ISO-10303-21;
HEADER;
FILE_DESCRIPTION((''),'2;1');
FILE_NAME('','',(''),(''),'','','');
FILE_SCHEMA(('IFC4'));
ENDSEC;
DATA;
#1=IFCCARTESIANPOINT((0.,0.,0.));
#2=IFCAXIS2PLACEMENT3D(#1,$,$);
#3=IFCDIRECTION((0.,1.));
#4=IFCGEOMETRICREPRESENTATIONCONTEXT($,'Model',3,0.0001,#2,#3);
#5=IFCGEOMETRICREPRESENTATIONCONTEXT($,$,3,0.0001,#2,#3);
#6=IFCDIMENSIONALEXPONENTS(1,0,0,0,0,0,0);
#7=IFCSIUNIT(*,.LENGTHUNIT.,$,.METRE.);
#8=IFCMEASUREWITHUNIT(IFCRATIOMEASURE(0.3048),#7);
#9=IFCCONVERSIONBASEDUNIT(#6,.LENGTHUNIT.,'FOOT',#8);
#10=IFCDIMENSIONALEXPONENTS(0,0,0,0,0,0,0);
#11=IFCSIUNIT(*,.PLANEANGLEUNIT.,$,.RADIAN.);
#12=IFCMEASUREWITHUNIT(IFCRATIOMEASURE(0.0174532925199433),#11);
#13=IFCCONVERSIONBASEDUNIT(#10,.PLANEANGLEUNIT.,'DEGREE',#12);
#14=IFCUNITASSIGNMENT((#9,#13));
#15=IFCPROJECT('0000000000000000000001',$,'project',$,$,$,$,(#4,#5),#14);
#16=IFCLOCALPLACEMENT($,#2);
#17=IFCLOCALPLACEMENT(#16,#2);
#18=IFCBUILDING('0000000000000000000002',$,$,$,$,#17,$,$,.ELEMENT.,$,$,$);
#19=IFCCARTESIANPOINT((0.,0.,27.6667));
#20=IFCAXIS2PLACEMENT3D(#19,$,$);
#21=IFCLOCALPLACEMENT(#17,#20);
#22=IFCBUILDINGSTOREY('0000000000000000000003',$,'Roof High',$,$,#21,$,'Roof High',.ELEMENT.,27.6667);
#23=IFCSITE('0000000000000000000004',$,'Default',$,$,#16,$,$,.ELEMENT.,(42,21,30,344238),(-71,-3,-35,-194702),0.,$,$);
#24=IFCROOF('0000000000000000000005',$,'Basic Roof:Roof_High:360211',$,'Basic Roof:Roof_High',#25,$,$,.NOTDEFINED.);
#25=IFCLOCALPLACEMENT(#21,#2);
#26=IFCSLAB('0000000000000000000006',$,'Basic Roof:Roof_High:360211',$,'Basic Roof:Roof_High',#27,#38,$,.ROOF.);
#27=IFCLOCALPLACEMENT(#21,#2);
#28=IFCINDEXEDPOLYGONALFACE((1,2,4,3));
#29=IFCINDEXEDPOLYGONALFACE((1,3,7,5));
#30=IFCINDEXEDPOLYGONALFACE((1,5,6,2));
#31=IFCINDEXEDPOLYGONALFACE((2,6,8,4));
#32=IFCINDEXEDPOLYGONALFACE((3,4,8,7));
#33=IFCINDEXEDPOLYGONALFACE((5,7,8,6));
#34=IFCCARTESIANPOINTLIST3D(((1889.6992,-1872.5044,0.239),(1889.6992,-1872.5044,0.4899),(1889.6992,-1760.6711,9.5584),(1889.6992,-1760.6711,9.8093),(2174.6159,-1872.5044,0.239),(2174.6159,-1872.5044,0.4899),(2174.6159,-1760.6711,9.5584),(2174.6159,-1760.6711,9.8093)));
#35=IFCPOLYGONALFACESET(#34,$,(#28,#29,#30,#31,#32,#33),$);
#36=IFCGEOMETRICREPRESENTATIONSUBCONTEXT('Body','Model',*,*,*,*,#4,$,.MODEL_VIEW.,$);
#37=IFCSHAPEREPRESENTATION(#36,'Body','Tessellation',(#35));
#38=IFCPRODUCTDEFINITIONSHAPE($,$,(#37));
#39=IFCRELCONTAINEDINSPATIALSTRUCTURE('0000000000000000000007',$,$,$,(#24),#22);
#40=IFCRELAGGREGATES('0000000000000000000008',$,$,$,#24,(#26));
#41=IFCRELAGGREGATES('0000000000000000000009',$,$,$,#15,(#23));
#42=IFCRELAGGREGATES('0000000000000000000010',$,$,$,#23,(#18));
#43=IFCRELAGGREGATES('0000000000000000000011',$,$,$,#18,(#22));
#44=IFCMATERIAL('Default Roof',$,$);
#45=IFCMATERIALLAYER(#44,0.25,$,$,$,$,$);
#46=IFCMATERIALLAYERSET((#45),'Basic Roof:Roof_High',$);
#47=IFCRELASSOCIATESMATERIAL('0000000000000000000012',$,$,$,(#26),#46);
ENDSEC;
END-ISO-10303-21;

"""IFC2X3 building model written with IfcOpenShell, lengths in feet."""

from ifc_helpers import new_model, entity, si_unit, converted_unit, direction, frame, frame_2d, origin, place, context, subcontext, project, spatial, rectangle, extrude, material, layer, layer_set, element, aggregate, save


model = new_model("IFC2X3")

# Units and contexts
model_context = context("Model", 3, precision=0.0001, world=origin(), true_north=direction((0.0, 1.0)))
context_of_model = context(None, 3, precision=0.0001, world=origin(), true_north=direction((0.0, 1.0)))
body_context = subcontext(model_context, "Body", "Model", "MODEL_VIEW")
ifc_project = project(units=[converted_unit("LENGTHUNIT", "FOOT", entity("IfcRatioMeasure", 0.3048), si_unit("LENGTHUNIT", "METRE"), dimensions=[1, 0, 0, 0, 0, 0, 0]), converted_unit("PLANEANGLEUNIT", "DEGREE", entity("IfcRatioMeasure", 0.0174532925199433), si_unit("PLANEANGLEUNIT", "RADIAN"), dimensions=[0, 0, 0, 0, 0, 0, 0])], contexts=[model_context, context_of_model])

# Site, building, storey
site_placement = place(None, origin())
site = spatial("IfcSite", under=ifc_project, at=site_placement, Name="Default", CompositionType="ELEMENT", RefLatitude=(42, 21, 30, 344238), RefLongitude=(-71, -3, -35, -194702), RefElevation=0.0)
building_placement = place(site_placement, origin())
building = spatial("IfcBuilding", under=site, at=building_placement, CompositionType="ELEMENT")
storey_placement = place(building_placement, frame((0.0, 0.0, 27.6667)))
storey = spatial("IfcBuildingStorey", under=building, at=storey_placement, Name="Roof High", LongName="Roof High", CompositionType="ELEMENT", Elevation=27.6667)

# Roof, slab
roof_placement = place(storey_placement, frame((1889.6992, -1872.5044, 0.239)))
roof = element("IfcRoof", 1, at=roof_placement, inside=storey, Name="Basic Roof:Roof_High:360211", ObjectType="Basic Roof:Roof_High", ShapeType="NOTDEFINED")
ifc_material = material(Name="Default Roof")
ifc_layer = layer(ifc_material, 0.25)
ifc_layer_set = layer_set([ifc_layer], Name="Basic Roof:Roof_High")
slab_placement = place(roof_placement, origin())
slab = element("IfcSlab", 2, at=slab_placement, material=ifc_layer_set, Name="Basic Roof:Roof_High:360211", ObjectType="Basic Roof:Roof_High", PredefinedType="ROOF", context=body_context, shape_type="SweptSolid", body=[
    extrude(rectangle(XDim=112.221, YDim=284.9167, at=frame_2d((0.0, 0.0), x_axis=(0.0, -1.0))), frame((142.4583, 55.9167, 4.6597), z_axis=(0.0, -0.083045, 0.996546), x_axis=(1.0, 0.0, 0.0)), (0.0, 0.083045, 0.996546), 0.2509),
])
aggregate(roof, [slab])

save(model, "model.ifc")
